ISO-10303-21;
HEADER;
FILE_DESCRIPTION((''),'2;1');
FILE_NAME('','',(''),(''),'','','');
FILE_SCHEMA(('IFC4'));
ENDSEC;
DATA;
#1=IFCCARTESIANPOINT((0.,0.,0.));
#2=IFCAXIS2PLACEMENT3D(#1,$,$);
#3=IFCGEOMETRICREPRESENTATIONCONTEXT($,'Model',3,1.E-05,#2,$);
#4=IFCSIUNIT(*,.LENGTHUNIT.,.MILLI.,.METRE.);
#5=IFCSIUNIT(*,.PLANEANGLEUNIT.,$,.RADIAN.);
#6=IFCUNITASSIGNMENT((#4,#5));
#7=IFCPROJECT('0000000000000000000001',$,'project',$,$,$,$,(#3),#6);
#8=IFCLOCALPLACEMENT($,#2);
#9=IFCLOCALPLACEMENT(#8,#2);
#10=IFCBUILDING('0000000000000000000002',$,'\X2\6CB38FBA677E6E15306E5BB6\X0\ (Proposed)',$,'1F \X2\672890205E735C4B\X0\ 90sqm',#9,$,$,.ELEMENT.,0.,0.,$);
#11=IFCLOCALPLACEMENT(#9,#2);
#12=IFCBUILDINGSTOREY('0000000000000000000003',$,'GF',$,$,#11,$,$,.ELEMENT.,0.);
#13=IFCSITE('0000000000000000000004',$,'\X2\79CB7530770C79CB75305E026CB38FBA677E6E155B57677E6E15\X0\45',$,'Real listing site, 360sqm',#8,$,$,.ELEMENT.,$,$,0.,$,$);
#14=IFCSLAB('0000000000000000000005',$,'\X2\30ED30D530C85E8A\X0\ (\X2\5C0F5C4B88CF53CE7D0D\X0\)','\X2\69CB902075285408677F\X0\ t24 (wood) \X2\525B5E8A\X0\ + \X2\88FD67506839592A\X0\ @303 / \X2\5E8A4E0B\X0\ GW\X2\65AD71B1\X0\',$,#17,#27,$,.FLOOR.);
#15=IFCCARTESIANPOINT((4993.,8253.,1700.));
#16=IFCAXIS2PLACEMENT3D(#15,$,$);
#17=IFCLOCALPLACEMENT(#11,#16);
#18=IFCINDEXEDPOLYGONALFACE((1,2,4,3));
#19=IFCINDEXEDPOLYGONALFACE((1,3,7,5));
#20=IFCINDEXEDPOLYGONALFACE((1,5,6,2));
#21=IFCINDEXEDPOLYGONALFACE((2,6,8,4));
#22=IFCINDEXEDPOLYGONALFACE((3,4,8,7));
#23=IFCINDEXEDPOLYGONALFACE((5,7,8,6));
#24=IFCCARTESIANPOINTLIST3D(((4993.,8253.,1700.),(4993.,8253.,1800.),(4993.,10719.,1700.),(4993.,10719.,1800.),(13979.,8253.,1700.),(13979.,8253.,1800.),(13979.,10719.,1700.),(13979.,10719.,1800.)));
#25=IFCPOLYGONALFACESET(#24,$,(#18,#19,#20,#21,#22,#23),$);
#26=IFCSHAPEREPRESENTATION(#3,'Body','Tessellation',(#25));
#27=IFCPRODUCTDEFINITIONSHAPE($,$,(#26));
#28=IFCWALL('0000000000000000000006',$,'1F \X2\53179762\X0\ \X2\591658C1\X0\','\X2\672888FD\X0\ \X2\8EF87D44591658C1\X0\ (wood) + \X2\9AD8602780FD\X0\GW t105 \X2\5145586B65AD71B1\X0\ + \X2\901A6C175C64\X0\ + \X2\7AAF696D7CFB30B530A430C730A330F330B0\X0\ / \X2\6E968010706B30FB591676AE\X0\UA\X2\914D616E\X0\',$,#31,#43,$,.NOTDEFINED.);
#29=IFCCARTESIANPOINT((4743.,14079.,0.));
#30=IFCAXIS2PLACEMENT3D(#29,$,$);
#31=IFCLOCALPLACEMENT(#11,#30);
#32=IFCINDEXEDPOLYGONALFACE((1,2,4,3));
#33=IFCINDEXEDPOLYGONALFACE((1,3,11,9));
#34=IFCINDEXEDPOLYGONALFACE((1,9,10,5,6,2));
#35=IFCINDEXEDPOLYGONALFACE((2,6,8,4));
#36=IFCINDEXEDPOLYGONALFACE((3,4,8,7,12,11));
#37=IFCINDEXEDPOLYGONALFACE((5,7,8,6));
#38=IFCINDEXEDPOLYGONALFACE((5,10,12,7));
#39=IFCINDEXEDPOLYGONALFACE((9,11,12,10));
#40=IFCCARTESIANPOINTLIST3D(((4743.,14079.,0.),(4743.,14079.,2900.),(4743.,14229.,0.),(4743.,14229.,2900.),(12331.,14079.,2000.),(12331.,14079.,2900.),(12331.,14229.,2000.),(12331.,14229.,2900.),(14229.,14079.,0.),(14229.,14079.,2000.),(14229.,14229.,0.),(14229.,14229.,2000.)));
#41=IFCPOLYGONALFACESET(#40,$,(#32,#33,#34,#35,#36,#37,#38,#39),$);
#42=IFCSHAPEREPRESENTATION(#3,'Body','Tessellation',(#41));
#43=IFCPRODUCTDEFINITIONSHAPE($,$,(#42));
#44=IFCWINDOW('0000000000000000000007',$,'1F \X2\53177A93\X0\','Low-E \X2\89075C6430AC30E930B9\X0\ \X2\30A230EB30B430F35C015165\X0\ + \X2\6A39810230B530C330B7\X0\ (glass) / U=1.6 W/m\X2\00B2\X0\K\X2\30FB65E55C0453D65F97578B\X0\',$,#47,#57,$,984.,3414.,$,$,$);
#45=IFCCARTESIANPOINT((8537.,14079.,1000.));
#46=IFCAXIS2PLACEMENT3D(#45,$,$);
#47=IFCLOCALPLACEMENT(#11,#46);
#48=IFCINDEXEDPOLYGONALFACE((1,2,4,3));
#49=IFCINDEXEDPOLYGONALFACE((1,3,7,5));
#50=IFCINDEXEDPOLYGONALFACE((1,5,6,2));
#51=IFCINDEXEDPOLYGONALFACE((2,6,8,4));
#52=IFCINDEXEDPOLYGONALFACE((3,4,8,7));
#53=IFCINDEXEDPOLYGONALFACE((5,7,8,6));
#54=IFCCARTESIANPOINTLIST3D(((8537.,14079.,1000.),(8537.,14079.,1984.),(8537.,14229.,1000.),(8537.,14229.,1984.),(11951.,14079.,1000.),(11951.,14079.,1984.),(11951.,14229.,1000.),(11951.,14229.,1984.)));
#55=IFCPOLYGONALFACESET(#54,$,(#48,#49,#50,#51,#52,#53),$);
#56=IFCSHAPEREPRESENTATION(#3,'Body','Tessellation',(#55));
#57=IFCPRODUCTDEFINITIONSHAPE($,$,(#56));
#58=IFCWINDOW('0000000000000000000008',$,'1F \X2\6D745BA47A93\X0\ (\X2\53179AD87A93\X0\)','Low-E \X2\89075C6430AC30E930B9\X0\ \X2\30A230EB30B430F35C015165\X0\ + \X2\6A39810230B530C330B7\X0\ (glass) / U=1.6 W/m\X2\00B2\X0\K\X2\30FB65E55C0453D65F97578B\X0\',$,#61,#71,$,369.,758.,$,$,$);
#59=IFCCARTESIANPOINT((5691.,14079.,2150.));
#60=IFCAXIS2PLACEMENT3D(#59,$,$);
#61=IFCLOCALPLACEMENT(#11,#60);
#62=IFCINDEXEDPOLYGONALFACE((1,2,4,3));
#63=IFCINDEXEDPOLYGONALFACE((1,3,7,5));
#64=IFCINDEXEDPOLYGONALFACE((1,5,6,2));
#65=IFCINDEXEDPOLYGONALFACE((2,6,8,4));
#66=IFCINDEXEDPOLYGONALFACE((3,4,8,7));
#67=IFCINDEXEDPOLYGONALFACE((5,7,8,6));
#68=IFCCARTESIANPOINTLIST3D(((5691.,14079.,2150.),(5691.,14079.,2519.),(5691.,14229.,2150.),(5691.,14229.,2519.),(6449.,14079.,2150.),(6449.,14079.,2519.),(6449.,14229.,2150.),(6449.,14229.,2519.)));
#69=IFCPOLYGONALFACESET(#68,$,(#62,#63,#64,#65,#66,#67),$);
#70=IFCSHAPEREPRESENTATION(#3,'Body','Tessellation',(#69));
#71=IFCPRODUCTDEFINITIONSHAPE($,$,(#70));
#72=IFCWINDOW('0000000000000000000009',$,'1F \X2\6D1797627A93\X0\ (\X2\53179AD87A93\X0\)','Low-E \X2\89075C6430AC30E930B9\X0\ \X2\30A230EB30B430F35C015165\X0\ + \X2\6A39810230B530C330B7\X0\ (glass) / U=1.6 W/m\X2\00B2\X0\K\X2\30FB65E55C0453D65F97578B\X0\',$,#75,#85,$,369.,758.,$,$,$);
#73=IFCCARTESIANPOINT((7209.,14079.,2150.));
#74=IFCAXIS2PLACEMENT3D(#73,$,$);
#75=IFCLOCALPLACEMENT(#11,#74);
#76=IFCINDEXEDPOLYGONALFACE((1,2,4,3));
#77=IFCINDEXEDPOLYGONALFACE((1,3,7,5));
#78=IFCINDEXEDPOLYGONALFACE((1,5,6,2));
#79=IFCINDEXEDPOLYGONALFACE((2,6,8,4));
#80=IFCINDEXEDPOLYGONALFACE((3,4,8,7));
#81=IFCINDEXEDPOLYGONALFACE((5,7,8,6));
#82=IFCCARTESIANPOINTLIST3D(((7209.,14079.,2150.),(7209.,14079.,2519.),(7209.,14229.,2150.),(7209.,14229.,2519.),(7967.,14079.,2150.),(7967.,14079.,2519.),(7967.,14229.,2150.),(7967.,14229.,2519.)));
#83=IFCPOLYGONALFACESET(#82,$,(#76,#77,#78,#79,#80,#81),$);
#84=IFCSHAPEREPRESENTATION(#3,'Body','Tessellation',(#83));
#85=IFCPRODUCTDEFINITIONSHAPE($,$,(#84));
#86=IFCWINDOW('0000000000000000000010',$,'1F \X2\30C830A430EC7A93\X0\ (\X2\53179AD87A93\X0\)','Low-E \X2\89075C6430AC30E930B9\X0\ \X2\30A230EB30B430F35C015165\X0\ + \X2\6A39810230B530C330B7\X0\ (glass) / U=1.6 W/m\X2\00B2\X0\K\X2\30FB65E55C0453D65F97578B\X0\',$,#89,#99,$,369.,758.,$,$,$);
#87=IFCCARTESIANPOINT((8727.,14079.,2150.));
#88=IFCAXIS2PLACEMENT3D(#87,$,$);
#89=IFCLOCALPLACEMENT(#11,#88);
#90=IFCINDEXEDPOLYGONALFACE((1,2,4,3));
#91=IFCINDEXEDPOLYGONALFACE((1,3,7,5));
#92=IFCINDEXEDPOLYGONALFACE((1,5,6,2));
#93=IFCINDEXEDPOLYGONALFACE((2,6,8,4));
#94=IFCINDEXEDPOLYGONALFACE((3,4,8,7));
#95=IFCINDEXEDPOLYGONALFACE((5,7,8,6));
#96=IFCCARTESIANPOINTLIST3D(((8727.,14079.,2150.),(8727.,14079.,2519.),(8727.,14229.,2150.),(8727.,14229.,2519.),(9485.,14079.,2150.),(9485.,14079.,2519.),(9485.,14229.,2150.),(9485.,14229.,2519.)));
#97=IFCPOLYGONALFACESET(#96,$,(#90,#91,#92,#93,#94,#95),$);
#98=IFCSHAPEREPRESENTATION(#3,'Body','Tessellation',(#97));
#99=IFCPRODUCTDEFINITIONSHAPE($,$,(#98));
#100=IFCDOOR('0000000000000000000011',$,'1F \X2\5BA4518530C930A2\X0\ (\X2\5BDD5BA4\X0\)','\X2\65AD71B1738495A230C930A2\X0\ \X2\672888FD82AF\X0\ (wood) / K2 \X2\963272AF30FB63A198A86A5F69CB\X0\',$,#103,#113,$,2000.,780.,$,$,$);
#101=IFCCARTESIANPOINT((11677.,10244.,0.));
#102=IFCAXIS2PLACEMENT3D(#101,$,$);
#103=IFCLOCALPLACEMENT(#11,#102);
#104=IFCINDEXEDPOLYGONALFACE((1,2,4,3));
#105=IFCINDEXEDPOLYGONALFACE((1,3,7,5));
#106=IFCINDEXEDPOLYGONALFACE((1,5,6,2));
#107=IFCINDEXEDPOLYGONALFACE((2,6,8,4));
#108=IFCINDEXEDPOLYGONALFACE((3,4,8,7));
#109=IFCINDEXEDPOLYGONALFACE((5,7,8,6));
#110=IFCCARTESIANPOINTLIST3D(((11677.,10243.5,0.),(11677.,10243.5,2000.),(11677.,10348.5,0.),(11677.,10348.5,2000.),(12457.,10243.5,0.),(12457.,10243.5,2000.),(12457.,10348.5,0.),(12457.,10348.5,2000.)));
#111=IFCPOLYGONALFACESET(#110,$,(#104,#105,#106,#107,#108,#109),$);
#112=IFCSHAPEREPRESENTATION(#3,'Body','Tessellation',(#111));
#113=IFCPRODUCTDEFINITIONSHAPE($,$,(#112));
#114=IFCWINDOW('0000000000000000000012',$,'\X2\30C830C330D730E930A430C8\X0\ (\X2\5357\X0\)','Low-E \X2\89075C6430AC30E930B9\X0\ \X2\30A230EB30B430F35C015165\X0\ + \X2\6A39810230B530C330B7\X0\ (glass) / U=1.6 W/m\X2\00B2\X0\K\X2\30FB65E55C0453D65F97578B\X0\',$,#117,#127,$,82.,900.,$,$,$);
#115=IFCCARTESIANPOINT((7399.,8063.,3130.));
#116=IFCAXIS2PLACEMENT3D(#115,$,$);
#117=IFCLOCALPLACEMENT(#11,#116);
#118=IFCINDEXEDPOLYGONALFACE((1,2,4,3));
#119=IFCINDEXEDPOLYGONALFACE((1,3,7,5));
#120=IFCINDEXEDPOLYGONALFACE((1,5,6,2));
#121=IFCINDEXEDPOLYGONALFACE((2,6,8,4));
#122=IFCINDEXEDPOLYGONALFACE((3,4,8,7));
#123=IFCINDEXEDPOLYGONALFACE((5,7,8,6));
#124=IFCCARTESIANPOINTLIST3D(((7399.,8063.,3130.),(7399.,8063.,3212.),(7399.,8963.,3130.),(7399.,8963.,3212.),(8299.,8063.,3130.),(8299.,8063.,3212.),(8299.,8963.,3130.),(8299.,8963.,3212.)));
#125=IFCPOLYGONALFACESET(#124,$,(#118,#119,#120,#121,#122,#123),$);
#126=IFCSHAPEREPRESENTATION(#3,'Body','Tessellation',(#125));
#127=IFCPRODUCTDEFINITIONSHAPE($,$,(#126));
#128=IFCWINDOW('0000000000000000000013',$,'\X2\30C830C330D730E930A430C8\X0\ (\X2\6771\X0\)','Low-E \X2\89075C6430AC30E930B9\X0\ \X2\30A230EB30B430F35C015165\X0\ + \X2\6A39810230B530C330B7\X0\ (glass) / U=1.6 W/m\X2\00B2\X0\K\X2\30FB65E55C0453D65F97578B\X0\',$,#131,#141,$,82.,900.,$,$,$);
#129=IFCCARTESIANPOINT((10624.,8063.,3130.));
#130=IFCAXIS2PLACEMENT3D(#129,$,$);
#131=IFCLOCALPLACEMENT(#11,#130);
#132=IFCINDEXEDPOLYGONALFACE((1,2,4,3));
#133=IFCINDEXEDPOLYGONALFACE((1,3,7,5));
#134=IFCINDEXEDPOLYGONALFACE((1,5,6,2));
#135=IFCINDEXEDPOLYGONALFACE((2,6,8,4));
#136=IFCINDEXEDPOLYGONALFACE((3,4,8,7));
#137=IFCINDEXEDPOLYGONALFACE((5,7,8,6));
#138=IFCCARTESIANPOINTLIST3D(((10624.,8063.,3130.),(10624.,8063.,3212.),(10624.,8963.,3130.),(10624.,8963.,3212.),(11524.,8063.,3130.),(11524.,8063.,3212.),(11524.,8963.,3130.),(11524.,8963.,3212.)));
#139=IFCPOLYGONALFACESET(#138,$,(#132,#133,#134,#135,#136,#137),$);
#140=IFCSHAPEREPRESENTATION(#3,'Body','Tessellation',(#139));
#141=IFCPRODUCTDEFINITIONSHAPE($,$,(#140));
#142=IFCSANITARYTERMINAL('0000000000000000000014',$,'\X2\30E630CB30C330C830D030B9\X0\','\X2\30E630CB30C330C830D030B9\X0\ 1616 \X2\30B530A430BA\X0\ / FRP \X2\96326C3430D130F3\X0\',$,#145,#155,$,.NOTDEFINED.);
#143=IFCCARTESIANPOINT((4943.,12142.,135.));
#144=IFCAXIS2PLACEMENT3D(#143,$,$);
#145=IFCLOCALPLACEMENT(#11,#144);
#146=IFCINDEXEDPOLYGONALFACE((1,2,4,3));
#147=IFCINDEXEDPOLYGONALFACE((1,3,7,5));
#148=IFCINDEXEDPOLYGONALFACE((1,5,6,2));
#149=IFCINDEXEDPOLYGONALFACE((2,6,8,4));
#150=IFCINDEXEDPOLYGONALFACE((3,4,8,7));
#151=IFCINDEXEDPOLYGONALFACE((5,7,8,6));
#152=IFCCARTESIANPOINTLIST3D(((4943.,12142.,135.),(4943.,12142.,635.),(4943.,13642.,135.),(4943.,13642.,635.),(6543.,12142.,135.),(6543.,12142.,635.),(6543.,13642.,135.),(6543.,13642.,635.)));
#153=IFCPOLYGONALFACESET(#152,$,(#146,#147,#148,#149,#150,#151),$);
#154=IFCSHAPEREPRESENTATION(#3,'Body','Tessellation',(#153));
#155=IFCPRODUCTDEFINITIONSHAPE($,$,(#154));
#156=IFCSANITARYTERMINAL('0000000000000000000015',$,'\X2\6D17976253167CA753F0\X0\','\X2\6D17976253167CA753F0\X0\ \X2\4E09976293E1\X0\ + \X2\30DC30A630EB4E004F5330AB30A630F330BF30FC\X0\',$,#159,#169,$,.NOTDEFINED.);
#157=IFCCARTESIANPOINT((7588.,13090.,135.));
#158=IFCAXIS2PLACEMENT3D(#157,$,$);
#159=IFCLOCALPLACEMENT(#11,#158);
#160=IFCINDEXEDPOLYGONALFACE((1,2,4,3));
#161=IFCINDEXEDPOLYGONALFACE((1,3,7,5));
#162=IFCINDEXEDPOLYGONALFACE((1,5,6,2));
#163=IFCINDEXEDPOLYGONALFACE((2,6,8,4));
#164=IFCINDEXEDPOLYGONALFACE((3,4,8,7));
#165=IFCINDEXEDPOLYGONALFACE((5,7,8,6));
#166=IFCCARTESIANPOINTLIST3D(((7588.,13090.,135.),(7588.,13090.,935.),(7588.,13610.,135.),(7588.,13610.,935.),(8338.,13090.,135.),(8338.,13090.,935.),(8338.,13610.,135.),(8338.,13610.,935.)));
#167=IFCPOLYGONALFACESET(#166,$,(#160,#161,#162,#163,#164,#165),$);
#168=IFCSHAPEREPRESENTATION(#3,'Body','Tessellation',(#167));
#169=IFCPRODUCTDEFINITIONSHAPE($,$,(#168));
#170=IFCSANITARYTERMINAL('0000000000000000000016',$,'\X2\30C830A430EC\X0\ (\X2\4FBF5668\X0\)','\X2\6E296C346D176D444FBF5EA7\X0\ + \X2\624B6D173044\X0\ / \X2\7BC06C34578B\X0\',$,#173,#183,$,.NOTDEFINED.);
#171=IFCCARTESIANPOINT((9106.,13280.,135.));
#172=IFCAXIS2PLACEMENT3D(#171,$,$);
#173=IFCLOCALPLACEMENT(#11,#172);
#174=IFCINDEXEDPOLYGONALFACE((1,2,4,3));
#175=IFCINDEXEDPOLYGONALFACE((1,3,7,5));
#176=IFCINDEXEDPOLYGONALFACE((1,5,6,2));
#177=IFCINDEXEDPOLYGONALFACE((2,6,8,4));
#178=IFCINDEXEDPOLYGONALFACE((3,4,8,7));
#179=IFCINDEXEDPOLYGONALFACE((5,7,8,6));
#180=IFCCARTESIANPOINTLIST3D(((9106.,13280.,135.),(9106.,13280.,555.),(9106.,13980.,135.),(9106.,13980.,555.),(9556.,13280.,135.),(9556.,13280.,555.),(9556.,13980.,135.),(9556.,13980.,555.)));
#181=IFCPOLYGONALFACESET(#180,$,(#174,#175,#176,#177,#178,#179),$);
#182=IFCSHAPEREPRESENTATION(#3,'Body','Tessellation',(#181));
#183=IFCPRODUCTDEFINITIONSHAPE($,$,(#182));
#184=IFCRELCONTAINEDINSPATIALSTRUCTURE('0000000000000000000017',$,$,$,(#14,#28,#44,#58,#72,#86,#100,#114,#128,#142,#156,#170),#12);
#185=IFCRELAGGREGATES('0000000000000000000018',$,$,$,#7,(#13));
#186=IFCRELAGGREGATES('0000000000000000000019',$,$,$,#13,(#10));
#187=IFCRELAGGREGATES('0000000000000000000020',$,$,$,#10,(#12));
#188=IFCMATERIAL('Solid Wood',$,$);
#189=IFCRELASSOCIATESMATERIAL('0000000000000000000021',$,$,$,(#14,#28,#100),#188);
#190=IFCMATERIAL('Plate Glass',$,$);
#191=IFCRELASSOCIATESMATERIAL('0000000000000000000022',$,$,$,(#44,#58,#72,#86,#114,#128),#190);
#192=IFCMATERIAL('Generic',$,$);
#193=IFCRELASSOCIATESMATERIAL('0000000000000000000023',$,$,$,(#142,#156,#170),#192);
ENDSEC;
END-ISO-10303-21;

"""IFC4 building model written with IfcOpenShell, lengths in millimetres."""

from ifc_helpers import new_model, si_unit, frame, frame_2d, origin, place, context, project, spatial, rectangle, extrude, material, element, fill, save


model = new_model("IFC4")

# Units and contexts
model_context = context("Model", 3, precision=1e-05, world=origin())
ifc_project = project(units=[si_unit("LENGTHUNIT", "METRE", prefix="MILLI"), si_unit("PLANEANGLEUNIT", "RADIAN")], contexts=[model_context])

# Site, building, storey
site_placement = place(None, origin())
site = spatial("IfcSite", under=ifc_project, at=site_placement, Name="秋田県秋田市河辺松渕字松渕45", ObjectType="Real listing site, 360sqm", CompositionType="ELEMENT", RefElevation=0.0)
building_placement = place(site_placement, origin())
building = spatial("IfcBuilding", under=site, at=building_placement, Name="河辺松渕の家 (Proposed)", ObjectType="1F 木造平屋 90sqm", CompositionType="ELEMENT", ElevationOfRefHeight=0.0, ElevationOfTerrain=0.0)
storey_placement = place(building_placement, origin())
storey = spatial("IfcBuildingStorey", under=building, at=storey_placement, Name="GF", CompositionType="ELEMENT", Elevation=0.0)

# Slab
ifc_material_1 = material(Name="Solid Wood")
slab_placement = place(storey_placement, frame((4993.0, 8253.0, 1700.0)))
element("IfcSlab", 1, at=slab_placement, inside=storey, material=ifc_material_1, Name="ロフト床 (小屋裏収納)", Description="構造用合板 t24 (wood) 剛床 + 製材根太 @303 / 床下 GW断熱", PredefinedType="FLOOR", context=model_context, shape_type="SweptSolid", body=[
    extrude(rectangle(XDim=8986.0, YDim=2466.0, at=frame_2d((4493.0, 1233.0))), frame((4993.0, 8253.0, 1700.0)), (0.0, 0.0, 1.0), 100.0),
])

# Wall, openings, windows
wall_1_placement = place(storey_placement, frame((4743.0, 14079.0, 0.0)))
wall_1 = element("IfcWall", 2, at=wall_1_placement, inside=storey, material=ifc_material_1, Name="1F 北面 外壁", Description="木製 軸組外壁 (wood) + 高性能GW t105 充填断熱 + 通気層 + 窯業系サイディング / 準耐火・外皮UA配慮", PredefinedType="NOTDEFINED", context=model_context, shape_type="SweptSolid", body=[
    extrude(rectangle(XDim=9486.0, YDim=150.0, at=frame_2d((4743.0, 75.0))), frame((4743.0, 14079.0, 0.0)), (0.0, 0.0, 1.0), 2900.0),
])
opening_1_placement = place(storey_placement, frame((8537.0, 14079.0, 1000.0)))
opening_1 = element("IfcOpeningElement", 3, at=opening_1_placement, cuts=wall_1, PredefinedType="NOTDEFINED", context=model_context, shape_type="SweptSolid", body=[
    extrude(rectangle(XDim=3414.0, YDim=150.0, at=frame_2d((1707.0, 75.0))), frame((8537.0, 14079.0, 1000.0)), (0.0, 0.0, 1.0), 984.0),
])
opening_2_placement = place(storey_placement, frame((5691.0, 14079.0, 2150.0)))
opening_2 = element("IfcOpeningElement", 4, at=opening_2_placement, cuts=wall_1, PredefinedType="NOTDEFINED", context=model_context, shape_type="SweptSolid", body=[
    extrude(rectangle(XDim=758.0, YDim=150.0, at=frame_2d((379.0, 75.0))), frame((5691.0, 14079.0, 2150.0)), (0.0, 0.0, 1.0), 369.0),
])
opening_3_placement = place(storey_placement, frame((7209.0, 14079.0, 2150.0)))
opening_3 = element("IfcOpeningElement", 5, at=opening_3_placement, cuts=wall_1, PredefinedType="NOTDEFINED", context=model_context, shape_type="SweptSolid", body=[
    extrude(rectangle(XDim=758.0, YDim=150.0, at=frame_2d((379.0, 75.0))), frame((7209.0, 14079.0, 2150.0)), (0.0, 0.0, 1.0), 369.0),
])
opening_4_placement = place(storey_placement, frame((8727.0, 14079.0, 2150.0)))
opening_4 = element("IfcOpeningElement", 6, at=opening_4_placement, cuts=wall_1, PredefinedType="NOTDEFINED", context=model_context, shape_type="SweptSolid", body=[
    extrude(rectangle(XDim=758.0, YDim=150.0, at=frame_2d((379.0, 75.0))), frame((8727.0, 14079.0, 2150.0)), (0.0, 0.0, 1.0), 369.0),
])
ifc_material_2 = material(Name="Plate Glass")
window_1_placement = place(storey_placement, frame((8537.0, 14079.0, 1000.0)))
window_1 = element("IfcWindow", 7, at=window_1_placement, inside=storey, material=ifc_material_2, Name="1F 北窓", Description="Low-E 複層ガラス アルゴン封入 + 樹脂サッシ (glass) / U=1.6 W/m²K・日射取得型", OverallHeight=984.0, OverallWidth=3414.0, context=model_context, shape_type="SweptSolid", body=[
    extrude(rectangle(XDim=3414.0, YDim=150.0, at=frame_2d((1707.0, 75.0))), frame((8537.0, 14079.0, 1000.0)), (0.0, 0.0, 1.0), 984.0),
])
fill(opening_1, window_1)
window_2_placement = place(storey_placement, frame((5691.0, 14079.0, 2150.0)))
window_2 = element("IfcWindow", 8, at=window_2_placement, inside=storey, material=ifc_material_2, Name="1F 浴室窓 (北高窓)", Description="Low-E 複層ガラス アルゴン封入 + 樹脂サッシ (glass) / U=1.6 W/m²K・日射取得型", OverallHeight=369.0, OverallWidth=758.0, context=model_context, shape_type="SweptSolid", body=[
    extrude(rectangle(XDim=758.0, YDim=150.0, at=frame_2d((379.0, 75.0))), frame((5691.0, 14079.0, 2150.0)), (0.0, 0.0, 1.0), 369.0),
])
fill(opening_2, window_2)
window_3_placement = place(storey_placement, frame((7209.0, 14079.0, 2150.0)))
window_3 = element("IfcWindow", 9, at=window_3_placement, inside=storey, material=ifc_material_2, Name="1F 洗面窓 (北高窓)", Description="Low-E 複層ガラス アルゴン封入 + 樹脂サッシ (glass) / U=1.6 W/m²K・日射取得型", OverallHeight=369.0, OverallWidth=758.0, context=model_context, shape_type="SweptSolid", body=[
    extrude(rectangle(XDim=758.0, YDim=150.0, at=frame_2d((379.0, 75.0))), frame((7209.0, 14079.0, 2150.0)), (0.0, 0.0, 1.0), 369.0),
])
fill(opening_3, window_3)
window_4_placement = place(storey_placement, frame((8727.0, 14079.0, 2150.0)))
window_4 = element("IfcWindow", 10, at=window_4_placement, inside=storey, material=ifc_material_2, Name="1F トイレ窓 (北高窓)", Description="Low-E 複層ガラス アルゴン封入 + 樹脂サッシ (glass) / U=1.6 W/m²K・日射取得型", OverallHeight=369.0, OverallWidth=758.0, context=model_context, shape_type="SweptSolid", body=[
    extrude(rectangle(XDim=758.0, YDim=150.0, at=frame_2d((379.0, 75.0))), frame((8727.0, 14079.0, 2150.0)), (0.0, 0.0, 1.0), 369.0),
])
fill(opening_4, window_4)

# Door
door_1_placement = place(storey_placement, frame((11677.0, 10244.0, 0.0)))
element("IfcDoor", 11, at=door_1_placement, inside=storey, material=ifc_material_1, Name="1F 室内ドア (寝室)", Description="断熱玄関ドア 木製芯 (wood) / K2 防犯・採風機構", OverallHeight=2000.0, OverallWidth=780.0, context=model_context, shape_type="SweptSolid", body=[
    extrude(rectangle(XDim=780.0, YDim=105.0, at=frame_2d((390.0, 52.0))), frame((11677.0, 10244.0, 0.0)), (0.0, 0.0, 1.0), 2000.0),
])

# Windows
window_5_placement = place(storey_placement, frame((7399.0, 8063.0, 3130.0)))
element("IfcWindow", 12, at=window_5_placement, inside=storey, material=ifc_material_2, Name="トップライト (南)", Description="Low-E 複層ガラス アルゴン封入 + 樹脂サッシ (glass) / U=1.6 W/m²K・日射取得型", OverallHeight=82.0, OverallWidth=900.0, context=model_context, shape_type="SweptSolid", body=[
    extrude(rectangle(XDim=900.0, YDim=900.0, at=frame_2d((450.0, 450.0))), frame((7399.0, 8063.0, 3130.0)), (0.0, 0.0, 1.0), 82.0),
])
window_6_placement = place(storey_placement, frame((10624.0, 8063.0, 3130.0)))
element("IfcWindow", 13, at=window_6_placement, inside=storey, material=ifc_material_2, Name="トップライト (東)", Description="Low-E 複層ガラス アルゴン封入 + 樹脂サッシ (glass) / U=1.6 W/m²K・日射取得型", OverallHeight=82.0, OverallWidth=900.0, context=model_context, shape_type="SweptSolid", body=[
    extrude(rectangle(XDim=900.0, YDim=900.0, at=frame_2d((450.0, 450.0))), frame((10624.0, 8063.0, 3130.0)), (0.0, 0.0, 1.0), 82.0),
])

# Sanitary terminals
ifc_material_3 = material(Name="Generic")
sanitary_terminal_1_placement = place(storey_placement, frame((4943.0, 12142.0, 135.0)))
element("IfcSanitaryTerminal", 14, at=sanitary_terminal_1_placement, inside=storey, material=ifc_material_3, Name="ユニットバス", Description="ユニットバス 1616 サイズ / FRP 防水パン", PredefinedType="NOTDEFINED", context=model_context, shape_type="SweptSolid", body=[
    extrude(rectangle(XDim=1600.0, YDim=1500.0, at=frame_2d((800.0, 750.0))), frame((4943.0, 12142.0, 135.0)), (0.0, 0.0, 1.0), 500.0),
])
sanitary_terminal_2_placement = place(storey_placement, frame((7588.0, 13090.0, 135.0)))
element("IfcSanitaryTerminal", 15, at=sanitary_terminal_2_placement, inside=storey, material=ifc_material_3, Name="洗面化粧台", Description="洗面化粧台 三面鏡 + ボウル一体カウンター", PredefinedType="NOTDEFINED", context=model_context, shape_type="SweptSolid", body=[
    extrude(rectangle(XDim=750.0, YDim=520.0, at=frame_2d((375.0, 260.0))), frame((7588.0, 13090.0, 135.0)), (0.0, 0.0, 1.0), 800.0),
])
sanitary_terminal_3_placement = place(storey_placement, frame((9106.0, 13280.0, 135.0)))
element("IfcSanitaryTerminal", 16, at=sanitary_terminal_3_placement, inside=storey, material=ifc_material_3, Name="トイレ (便器)", Description="温水洗浄便座 + 手洗い / 節水型", PredefinedType="NOTDEFINED", context=model_context, shape_type="SweptSolid", body=[
    extrude(rectangle(XDim=450.0, YDim=700.0, at=frame_2d((225.0, 350.0))), frame((9106.0, 13280.0, 135.0)), (0.0, 0.0, 1.0), 420.0),
])

save(model, "model.ifc")
